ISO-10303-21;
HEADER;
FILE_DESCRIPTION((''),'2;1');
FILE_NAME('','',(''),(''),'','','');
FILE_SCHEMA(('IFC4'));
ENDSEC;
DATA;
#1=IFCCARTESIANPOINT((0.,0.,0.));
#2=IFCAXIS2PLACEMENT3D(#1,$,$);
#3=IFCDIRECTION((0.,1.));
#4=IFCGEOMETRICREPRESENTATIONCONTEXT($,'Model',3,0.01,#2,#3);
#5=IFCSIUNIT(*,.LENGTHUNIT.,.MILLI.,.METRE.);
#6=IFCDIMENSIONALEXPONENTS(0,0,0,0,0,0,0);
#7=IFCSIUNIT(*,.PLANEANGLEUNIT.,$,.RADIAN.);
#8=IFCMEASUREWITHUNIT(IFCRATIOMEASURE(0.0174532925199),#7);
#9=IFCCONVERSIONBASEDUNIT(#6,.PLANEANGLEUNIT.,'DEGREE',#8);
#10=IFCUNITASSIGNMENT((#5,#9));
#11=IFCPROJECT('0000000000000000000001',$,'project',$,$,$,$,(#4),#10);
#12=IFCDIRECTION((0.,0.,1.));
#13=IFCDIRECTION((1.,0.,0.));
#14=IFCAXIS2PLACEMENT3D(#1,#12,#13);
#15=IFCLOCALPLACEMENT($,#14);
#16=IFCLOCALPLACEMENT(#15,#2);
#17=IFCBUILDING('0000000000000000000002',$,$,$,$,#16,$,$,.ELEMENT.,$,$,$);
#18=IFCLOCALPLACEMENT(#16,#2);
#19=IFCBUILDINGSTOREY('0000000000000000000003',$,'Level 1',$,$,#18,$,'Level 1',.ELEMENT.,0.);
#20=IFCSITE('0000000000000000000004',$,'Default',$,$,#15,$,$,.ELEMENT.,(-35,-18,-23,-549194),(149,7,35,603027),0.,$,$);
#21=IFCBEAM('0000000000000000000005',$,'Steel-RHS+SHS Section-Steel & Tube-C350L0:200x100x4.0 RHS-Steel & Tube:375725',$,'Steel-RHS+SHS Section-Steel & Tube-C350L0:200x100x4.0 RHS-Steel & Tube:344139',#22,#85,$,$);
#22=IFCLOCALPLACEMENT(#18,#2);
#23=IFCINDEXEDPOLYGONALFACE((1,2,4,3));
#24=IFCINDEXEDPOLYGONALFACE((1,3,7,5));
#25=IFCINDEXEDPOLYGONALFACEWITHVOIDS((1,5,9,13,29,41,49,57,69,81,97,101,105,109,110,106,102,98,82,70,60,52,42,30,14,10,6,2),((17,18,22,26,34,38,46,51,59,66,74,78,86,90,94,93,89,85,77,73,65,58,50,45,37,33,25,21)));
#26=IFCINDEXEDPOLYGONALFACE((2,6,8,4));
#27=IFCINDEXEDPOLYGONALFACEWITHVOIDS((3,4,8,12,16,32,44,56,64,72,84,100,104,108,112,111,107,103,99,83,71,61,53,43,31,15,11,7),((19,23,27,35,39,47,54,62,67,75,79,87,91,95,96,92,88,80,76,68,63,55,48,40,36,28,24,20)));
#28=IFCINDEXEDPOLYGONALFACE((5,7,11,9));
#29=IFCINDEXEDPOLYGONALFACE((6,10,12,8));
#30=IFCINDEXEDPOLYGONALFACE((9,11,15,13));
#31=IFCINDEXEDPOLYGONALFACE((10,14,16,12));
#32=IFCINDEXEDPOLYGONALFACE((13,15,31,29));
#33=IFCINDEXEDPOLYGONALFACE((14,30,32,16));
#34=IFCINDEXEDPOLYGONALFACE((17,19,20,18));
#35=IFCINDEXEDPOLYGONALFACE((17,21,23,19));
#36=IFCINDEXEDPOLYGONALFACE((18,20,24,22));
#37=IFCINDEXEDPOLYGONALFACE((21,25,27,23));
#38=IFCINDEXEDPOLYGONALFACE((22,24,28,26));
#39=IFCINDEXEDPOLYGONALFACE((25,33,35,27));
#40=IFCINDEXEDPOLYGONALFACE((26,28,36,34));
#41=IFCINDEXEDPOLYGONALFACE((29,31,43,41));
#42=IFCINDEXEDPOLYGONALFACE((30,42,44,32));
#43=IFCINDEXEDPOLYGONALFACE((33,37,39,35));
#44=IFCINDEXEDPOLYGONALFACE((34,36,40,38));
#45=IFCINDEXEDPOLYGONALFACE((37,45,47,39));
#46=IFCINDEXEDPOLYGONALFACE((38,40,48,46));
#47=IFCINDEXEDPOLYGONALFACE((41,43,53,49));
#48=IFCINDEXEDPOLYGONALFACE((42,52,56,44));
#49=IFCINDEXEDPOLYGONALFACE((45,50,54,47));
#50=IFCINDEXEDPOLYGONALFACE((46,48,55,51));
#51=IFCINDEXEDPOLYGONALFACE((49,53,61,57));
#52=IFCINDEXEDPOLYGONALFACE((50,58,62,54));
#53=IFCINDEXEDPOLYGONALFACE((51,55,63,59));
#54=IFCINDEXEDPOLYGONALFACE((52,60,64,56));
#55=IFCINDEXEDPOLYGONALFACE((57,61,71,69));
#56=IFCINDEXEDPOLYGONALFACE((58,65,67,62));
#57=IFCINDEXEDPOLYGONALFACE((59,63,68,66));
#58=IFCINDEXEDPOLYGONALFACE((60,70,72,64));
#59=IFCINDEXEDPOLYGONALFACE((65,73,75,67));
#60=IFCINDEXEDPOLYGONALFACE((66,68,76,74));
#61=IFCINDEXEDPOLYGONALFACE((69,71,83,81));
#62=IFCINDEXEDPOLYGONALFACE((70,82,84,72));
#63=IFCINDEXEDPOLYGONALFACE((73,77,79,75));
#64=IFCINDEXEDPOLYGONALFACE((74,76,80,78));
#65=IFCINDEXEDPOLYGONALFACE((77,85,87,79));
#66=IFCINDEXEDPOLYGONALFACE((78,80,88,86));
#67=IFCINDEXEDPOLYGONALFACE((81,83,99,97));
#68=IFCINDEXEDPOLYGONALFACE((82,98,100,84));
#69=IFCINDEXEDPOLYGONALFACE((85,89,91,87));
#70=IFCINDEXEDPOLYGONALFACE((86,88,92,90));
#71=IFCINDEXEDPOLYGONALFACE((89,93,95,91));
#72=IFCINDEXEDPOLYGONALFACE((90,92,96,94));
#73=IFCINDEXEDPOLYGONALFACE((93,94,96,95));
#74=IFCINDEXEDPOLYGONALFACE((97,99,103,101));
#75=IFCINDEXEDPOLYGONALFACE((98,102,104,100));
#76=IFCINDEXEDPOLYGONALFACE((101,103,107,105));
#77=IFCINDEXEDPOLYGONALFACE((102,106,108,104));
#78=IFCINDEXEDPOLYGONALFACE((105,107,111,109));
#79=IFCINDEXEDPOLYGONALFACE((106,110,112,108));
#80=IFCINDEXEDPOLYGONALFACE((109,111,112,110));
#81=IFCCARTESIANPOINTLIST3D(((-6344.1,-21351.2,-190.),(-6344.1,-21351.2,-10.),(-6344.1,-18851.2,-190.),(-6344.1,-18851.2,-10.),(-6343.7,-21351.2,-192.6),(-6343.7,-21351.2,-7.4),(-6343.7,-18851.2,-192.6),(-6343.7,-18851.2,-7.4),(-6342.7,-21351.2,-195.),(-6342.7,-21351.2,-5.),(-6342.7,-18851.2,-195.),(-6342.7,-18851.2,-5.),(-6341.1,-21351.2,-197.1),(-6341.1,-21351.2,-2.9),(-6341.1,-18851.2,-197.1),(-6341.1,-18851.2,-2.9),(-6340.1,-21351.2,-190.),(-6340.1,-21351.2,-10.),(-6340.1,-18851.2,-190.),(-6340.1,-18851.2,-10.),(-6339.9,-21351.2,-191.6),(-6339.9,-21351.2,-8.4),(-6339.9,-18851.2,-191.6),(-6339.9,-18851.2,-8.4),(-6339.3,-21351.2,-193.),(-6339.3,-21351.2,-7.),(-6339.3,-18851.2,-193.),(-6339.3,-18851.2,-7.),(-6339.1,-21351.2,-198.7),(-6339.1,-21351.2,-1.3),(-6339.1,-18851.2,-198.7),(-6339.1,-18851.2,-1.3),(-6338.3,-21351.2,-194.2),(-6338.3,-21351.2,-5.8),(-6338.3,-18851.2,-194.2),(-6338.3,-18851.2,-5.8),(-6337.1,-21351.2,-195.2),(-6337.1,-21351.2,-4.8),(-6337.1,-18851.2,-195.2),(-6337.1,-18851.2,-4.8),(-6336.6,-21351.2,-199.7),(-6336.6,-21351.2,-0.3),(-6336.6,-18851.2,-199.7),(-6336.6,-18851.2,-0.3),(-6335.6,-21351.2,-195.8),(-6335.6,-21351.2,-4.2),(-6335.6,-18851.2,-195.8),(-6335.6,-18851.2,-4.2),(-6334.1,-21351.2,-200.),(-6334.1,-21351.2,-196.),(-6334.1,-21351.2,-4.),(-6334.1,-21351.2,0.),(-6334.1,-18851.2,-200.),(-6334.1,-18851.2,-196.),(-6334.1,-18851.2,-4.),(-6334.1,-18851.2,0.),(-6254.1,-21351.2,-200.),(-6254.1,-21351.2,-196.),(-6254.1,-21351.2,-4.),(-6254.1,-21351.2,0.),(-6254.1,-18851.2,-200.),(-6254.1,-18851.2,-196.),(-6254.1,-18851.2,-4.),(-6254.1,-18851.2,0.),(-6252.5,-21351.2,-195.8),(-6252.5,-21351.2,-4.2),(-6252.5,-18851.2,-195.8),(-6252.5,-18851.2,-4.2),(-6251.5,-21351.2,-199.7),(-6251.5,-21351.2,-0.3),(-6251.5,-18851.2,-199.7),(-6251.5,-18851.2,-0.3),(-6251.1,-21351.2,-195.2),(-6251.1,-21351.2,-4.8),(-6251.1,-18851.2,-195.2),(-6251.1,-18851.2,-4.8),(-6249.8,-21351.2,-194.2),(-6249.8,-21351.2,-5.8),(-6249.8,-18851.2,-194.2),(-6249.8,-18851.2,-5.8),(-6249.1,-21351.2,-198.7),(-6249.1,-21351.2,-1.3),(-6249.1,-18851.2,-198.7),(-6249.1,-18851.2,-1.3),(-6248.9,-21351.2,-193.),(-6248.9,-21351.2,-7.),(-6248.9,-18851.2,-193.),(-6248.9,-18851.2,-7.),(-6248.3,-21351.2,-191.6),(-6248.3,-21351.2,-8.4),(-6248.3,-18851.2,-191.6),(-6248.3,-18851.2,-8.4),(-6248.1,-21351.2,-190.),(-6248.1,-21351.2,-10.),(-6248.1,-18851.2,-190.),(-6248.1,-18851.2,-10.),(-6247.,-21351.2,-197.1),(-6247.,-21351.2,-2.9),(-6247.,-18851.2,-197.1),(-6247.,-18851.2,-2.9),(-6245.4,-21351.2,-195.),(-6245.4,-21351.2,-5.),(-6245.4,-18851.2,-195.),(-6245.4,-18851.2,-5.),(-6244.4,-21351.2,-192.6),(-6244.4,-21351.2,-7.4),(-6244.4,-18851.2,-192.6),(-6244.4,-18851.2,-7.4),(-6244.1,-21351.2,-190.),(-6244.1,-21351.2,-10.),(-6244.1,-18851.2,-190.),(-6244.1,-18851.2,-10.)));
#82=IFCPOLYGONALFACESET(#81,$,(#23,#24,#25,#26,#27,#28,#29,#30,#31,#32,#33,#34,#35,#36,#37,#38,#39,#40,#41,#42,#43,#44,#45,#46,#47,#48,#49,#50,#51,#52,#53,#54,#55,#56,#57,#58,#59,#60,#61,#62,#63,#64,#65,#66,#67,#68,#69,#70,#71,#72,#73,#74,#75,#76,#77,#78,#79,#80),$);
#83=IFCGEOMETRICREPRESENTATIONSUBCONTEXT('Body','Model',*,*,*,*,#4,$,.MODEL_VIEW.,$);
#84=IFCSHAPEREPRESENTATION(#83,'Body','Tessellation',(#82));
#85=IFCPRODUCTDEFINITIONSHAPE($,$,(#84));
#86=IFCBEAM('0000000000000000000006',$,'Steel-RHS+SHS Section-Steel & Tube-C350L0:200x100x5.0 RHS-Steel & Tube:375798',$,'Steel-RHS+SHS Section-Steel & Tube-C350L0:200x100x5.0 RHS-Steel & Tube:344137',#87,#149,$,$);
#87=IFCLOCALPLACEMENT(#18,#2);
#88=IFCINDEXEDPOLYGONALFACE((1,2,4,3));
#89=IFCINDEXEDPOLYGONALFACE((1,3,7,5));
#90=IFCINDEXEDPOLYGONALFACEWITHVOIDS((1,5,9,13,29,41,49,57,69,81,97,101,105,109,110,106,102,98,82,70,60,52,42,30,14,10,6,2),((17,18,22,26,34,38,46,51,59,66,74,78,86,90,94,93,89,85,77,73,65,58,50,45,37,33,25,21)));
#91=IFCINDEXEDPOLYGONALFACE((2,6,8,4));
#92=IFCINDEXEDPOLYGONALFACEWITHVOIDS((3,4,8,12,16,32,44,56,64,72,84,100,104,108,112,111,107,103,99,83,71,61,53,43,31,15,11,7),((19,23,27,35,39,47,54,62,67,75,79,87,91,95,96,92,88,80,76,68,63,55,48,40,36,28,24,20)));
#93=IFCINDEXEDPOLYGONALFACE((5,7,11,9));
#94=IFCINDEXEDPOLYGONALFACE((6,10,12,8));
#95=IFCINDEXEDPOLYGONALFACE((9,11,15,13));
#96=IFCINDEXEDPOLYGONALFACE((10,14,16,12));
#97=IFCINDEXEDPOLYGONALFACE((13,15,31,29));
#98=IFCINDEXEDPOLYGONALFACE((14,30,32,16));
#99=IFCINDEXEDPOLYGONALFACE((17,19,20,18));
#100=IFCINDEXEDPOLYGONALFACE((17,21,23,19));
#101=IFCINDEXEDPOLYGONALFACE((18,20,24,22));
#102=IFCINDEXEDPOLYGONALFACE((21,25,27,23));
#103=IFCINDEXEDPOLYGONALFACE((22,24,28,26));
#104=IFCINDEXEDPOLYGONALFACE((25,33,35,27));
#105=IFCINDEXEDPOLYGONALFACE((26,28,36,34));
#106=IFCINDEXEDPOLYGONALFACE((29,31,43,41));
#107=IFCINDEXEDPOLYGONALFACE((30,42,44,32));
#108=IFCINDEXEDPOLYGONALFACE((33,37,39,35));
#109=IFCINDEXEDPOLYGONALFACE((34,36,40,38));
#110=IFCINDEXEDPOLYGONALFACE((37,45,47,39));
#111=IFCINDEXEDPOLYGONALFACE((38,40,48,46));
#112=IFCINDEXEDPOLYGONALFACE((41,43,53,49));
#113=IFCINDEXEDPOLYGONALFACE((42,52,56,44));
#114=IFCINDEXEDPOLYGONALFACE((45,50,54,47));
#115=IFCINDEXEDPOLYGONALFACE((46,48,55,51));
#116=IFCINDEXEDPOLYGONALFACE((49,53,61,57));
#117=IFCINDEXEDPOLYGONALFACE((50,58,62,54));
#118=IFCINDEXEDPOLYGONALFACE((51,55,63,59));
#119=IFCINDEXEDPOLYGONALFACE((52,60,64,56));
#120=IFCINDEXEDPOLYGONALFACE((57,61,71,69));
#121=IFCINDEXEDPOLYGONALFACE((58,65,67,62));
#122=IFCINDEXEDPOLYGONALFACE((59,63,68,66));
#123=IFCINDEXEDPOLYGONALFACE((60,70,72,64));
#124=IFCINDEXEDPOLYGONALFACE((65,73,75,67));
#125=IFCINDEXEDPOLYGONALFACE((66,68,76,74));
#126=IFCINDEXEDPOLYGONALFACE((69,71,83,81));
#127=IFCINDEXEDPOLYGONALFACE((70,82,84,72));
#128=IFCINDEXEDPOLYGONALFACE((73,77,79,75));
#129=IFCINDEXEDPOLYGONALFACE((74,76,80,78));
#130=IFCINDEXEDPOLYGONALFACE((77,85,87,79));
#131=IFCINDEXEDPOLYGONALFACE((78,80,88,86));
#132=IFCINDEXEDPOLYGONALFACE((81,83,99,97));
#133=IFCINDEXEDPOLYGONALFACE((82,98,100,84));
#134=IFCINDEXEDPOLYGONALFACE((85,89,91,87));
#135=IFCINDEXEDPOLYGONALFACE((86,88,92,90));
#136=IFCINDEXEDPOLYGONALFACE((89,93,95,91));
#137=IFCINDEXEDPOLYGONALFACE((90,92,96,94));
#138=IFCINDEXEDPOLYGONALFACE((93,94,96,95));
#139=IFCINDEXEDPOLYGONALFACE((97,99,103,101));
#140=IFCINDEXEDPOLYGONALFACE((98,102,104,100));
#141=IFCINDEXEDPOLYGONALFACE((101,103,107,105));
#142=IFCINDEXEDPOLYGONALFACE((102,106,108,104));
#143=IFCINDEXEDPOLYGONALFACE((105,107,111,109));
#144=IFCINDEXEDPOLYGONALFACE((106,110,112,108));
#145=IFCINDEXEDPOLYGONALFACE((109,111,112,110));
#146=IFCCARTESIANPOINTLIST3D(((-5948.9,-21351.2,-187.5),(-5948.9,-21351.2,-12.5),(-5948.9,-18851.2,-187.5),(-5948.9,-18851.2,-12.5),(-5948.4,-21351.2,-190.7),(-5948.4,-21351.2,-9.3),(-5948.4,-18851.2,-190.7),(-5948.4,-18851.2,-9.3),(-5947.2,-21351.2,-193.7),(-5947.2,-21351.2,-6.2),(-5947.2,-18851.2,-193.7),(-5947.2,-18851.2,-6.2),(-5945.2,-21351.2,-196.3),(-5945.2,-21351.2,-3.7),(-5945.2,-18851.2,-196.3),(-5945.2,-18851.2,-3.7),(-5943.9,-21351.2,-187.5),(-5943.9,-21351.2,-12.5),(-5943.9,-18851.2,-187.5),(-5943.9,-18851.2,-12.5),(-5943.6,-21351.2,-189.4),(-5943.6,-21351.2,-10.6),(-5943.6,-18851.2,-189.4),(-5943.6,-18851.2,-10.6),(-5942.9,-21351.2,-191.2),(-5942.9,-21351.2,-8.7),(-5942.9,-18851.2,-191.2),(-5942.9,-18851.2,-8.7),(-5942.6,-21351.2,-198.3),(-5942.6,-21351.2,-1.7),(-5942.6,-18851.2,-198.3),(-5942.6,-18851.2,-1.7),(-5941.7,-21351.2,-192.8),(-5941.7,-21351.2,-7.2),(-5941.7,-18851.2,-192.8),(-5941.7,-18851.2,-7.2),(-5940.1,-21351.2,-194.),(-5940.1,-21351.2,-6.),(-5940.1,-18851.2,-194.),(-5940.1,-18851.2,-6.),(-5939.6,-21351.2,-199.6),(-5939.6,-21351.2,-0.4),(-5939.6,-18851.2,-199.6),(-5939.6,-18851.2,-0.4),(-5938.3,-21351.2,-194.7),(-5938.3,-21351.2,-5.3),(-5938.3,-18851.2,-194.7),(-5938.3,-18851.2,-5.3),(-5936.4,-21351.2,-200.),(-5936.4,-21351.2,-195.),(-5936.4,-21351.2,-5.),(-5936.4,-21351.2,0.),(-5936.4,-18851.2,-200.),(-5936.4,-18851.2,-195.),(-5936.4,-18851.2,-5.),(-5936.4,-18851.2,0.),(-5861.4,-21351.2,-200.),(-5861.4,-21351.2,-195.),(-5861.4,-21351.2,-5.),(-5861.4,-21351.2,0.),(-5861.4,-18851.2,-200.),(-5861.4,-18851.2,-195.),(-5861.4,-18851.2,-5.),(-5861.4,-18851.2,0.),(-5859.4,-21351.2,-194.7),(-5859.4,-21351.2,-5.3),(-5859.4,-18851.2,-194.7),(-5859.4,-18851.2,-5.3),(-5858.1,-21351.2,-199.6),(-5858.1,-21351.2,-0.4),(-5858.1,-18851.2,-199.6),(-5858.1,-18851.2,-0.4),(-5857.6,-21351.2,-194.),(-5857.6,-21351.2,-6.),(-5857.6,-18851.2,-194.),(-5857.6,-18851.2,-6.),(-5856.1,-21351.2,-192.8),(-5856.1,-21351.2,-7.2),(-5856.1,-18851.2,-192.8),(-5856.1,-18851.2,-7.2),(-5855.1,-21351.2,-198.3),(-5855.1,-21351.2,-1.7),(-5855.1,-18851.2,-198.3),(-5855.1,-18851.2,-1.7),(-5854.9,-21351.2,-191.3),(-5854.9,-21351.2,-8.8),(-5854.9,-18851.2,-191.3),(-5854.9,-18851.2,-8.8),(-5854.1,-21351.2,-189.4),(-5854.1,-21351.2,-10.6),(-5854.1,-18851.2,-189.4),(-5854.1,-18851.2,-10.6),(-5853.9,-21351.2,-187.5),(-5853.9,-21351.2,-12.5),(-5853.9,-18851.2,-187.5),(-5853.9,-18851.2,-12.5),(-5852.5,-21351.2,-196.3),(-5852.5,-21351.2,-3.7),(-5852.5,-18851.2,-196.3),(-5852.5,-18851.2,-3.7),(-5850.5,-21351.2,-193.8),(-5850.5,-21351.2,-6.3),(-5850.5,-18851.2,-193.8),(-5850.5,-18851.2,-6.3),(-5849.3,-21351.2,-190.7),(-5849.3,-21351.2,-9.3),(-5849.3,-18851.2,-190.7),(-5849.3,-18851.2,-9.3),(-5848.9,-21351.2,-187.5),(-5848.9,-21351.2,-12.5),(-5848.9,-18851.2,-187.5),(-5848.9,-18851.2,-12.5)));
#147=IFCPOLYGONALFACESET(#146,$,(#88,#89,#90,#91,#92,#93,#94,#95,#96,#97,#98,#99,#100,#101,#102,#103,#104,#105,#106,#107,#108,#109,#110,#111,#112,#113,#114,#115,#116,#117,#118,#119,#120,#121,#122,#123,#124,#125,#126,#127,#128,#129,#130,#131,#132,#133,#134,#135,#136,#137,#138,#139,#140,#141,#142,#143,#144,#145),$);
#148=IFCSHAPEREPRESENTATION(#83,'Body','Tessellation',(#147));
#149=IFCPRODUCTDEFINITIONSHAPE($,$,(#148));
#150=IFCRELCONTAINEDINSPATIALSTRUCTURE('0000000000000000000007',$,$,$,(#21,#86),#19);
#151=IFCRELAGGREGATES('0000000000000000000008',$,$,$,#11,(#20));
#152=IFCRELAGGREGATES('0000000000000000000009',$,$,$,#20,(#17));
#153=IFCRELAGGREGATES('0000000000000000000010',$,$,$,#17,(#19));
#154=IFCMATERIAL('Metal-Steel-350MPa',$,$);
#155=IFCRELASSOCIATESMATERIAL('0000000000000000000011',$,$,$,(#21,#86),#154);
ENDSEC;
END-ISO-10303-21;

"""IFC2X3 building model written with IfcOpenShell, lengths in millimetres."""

from ifc_helpers import new_model, entity, si_unit, converted_unit, direction, frame, frame_2d, origin, origin_with_axes, place, context, subcontext, project, spatial, polyline, circle_curve, parameter, trimmed, segment, composite_curve, outline, extrude, material, element, save


model = new_model("IFC2X3")

# Units and contexts
model_context = context("Model", 3, precision=0.01, world=origin(), true_north=direction((0.0, 1.0)))
body_context = subcontext(model_context, "Body", "Model", "MODEL_VIEW")
ifc_project = project(units=[si_unit("LENGTHUNIT", "METRE", prefix="MILLI"), converted_unit("PLANEANGLEUNIT", "DEGREE", entity("IfcRatioMeasure", 0.0174532925199), si_unit("PLANEANGLEUNIT", "RADIAN"), dimensions=[0, 0, 0, 0, 0, 0, 0])], contexts=[model_context])

# Site, building, storey
site_placement = place(None, origin_with_axes())
site = spatial("IfcSite", under=ifc_project, at=site_placement, Name="Default", CompositionType="ELEMENT", RefLatitude=(-35, -18, -23, -549194), RefLongitude=(149, 7, 35, 603027), RefElevation=0.0)
building_placement = place(site_placement, origin())
building = spatial("IfcBuilding", under=site, at=building_placement, CompositionType="ELEMENT")
storey_placement = place(building_placement, origin())
storey = spatial("IfcBuildingStorey", under=building, at=storey_placement, Name="Level 1", LongName="Level 1", CompositionType="ELEMENT", Elevation=0.0)

# Beams
ifc_material = material(Name="Metal-Steel-350MPa")
beam_1_placement = place(storey_placement, frame((-6294.1, -18851.2, 0.0), z_axis=(0.0, 0.0, 1.0), x_axis=(0.0, -1.0, 0.0)))
element("IfcBeam", 1, at=beam_1_placement, inside=storey, material=ifc_material, Name="Steel-RHS+SHS Section-Steel & Tube-C350L0:200x100x4.0 RHS-Steel & Tube:375725", ObjectType="Steel-RHS+SHS Section-Steel & Tube-C350L0:200x100x4.0 RHS-Steel & Tube:344139", context=body_context, shape_type="SweptSolid", body=[
    extrude(outline(composite_curve([segment(trimmed(circle_curve(frame_2d((-40.0, -90.0), x_axis=(1.0, 0.0)), 10.0), [parameter(180.0)], [parameter(270.0)], True, "PARAMETER"), True, "CONTINUOUS"), segment(polyline([(-40.0, -100.0), (40.0, -100.0)]), True, "CONTINUOUS"), segment(trimmed(circle_curve(frame_2d((40.0, -90.0), x_axis=(1.0, 0.0)), 10.0), [parameter(270.0)], [parameter(0.0)], True, "PARAMETER"), True, "CONTINUOUS"), segment(polyline([(50.0, -90.0), (50.0, 90.0)]), True, "CONTINUOUS"), segment(trimmed(circle_curve(frame_2d((40.0, 90.0), x_axis=(1.0, 0.0)), 10.0), [parameter(0.0)], [parameter(90.0)], True, "PARAMETER"), True, "CONTINUOUS"), segment(polyline([(40.0, 100.0), (-40.0, 100.0)]), True, "CONTINUOUS"), segment(trimmed(circle_curve(frame_2d((-40.0, 90.0), x_axis=(1.0, 0.0)), 10.0), [parameter(90.0)], [parameter(180.0)], True, "PARAMETER"), True, "CONTINUOUS"), segment(polyline([(-50.0, 90.0), (-50.0, -90.0)]), True, "CONTINUOUS")], self_intersect=False), holes=[composite_curve([segment(polyline([(40.0, -96.0), (-40.0, -96.0)]), True, "CONTINUOUS"), segment(trimmed(circle_curve(frame_2d((-40.0, -90.0), x_axis=(1.0, 0.0)), 6.0), [parameter(180.0)], [parameter(270.0)], True, "PARAMETER"), False, "CONTINUOUS"), segment(polyline([(-46.0, -90.0), (-46.0, 90.0)]), True, "CONTINUOUS"), segment(trimmed(circle_curve(frame_2d((-40.0, 90.0), x_axis=(1.0, 0.0)), 6.0), [parameter(90.0)], [parameter(180.0)], True, "PARAMETER"), False, "CONTINUOUS"), segment(polyline([(-40.0, 96.0), (40.0, 96.0)]), True, "CONTINUOUS"), segment(trimmed(circle_curve(frame_2d((40.0, 90.0), x_axis=(1.0, 0.0)), 6.0), [parameter(360.0)], [parameter(90.0)], True, "PARAMETER"), False, "CONTINUOUS"), segment(polyline([(46.0, 90.0), (46.0, -90.0)]), True, "CONTINUOUS"), segment(trimmed(circle_curve(frame_2d((40.0, -90.0), x_axis=(1.0, 0.0)), 6.0), [parameter(270.0)], [parameter(360.0)], True, "PARAMETER"), False, "CONTINUOUS")], self_intersect=False)]), frame((0.0, 0.0, -100.0), z_axis=(1.0, 0.0, 0.0), x_axis=(0.0, -1.0, 0.0)), (0.0, 0.0, 1.0), 2500.0),
])
beam_2_placement = place(storey_placement, frame((-5898.9, -18851.2, 0.0), z_axis=(0.0, 0.0, 1.0), x_axis=(0.0, -1.0, 0.0)))
element("IfcBeam", 2, at=beam_2_placement, inside=storey, material=ifc_material, Name="Steel-RHS+SHS Section-Steel & Tube-C350L0:200x100x5.0 RHS-Steel & Tube:375798", ObjectType="Steel-RHS+SHS Section-Steel & Tube-C350L0:200x100x5.0 RHS-Steel & Tube:344137", context=body_context, shape_type="SweptSolid", body=[
    extrude(outline(composite_curve([segment(trimmed(circle_curve(frame_2d((-37.5, -87.5), x_axis=(1.0, 0.0)), 12.5), [parameter(180.0)], [parameter(270.0)], True, "PARAMETER"), True, "CONTINUOUS"), segment(polyline([(-37.5, -100.0), (37.5, -100.0)]), True, "CONTINUOUS"), segment(trimmed(circle_curve(frame_2d((37.5, -87.5), x_axis=(1.0, 0.0)), 12.5), [parameter(270.0)], [parameter(0.0)], True, "PARAMETER"), True, "CONTINUOUS"), segment(polyline([(50.0, -87.5), (50.0, 87.5)]), True, "CONTINUOUS"), segment(trimmed(circle_curve(frame_2d((37.5, 87.5), x_axis=(1.0, 0.0)), 12.5), [parameter(0.0)], [parameter(90.0)], True, "PARAMETER"), True, "CONTINUOUS"), segment(polyline([(37.5, 100.0), (-37.5, 100.0)]), True, "CONTINUOUS"), segment(trimmed(circle_curve(frame_2d((-37.5, 87.5), x_axis=(1.0, 0.0)), 12.5), [parameter(90.0)], [parameter(180.0)], True, "PARAMETER"), True, "CONTINUOUS"), segment(polyline([(-50.0, 87.5), (-50.0, -87.5)]), True, "CONTINUOUS")], self_intersect=False), holes=[composite_curve([segment(polyline([(37.5, -95.0), (-37.5, -95.0)]), True, "CONTINUOUS"), segment(trimmed(circle_curve(frame_2d((-37.5, -87.5), x_axis=(1.0, 0.0)), 7.5), [parameter(180.0)], [parameter(270.0)], True, "PARAMETER"), False, "CONTINUOUS"), segment(polyline([(-45.0, -87.5), (-45.0, 87.5)]), True, "CONTINUOUS"), segment(trimmed(circle_curve(frame_2d((-37.5, 87.5), x_axis=(1.0, 0.0)), 7.5), [parameter(90.0)], [parameter(180.0)], True, "PARAMETER"), False, "CONTINUOUS"), segment(polyline([(-37.5, 95.0), (37.5, 95.0)]), True, "CONTINUOUS"), segment(trimmed(circle_curve(frame_2d((37.5, 87.5), x_axis=(1.0, 0.0)), 7.5), [parameter(360.0)], [parameter(90.0)], True, "PARAMETER"), False, "CONTINUOUS"), segment(polyline([(45.0, 87.5), (45.0, -87.5)]), True, "CONTINUOUS"), segment(trimmed(circle_curve(frame_2d((37.5, -87.5), x_axis=(1.0, 0.0)), 7.5), [parameter(270.0)], [parameter(360.0)], True, "PARAMETER"), False, "CONTINUOUS")], self_intersect=False)]), frame((0.0, 0.0, -100.0), z_axis=(1.0, 0.0, 0.0), x_axis=(0.0, -1.0, 0.0)), (0.0, 0.0, 1.0), 2500.0),
])

save(model, "model.ifc")
